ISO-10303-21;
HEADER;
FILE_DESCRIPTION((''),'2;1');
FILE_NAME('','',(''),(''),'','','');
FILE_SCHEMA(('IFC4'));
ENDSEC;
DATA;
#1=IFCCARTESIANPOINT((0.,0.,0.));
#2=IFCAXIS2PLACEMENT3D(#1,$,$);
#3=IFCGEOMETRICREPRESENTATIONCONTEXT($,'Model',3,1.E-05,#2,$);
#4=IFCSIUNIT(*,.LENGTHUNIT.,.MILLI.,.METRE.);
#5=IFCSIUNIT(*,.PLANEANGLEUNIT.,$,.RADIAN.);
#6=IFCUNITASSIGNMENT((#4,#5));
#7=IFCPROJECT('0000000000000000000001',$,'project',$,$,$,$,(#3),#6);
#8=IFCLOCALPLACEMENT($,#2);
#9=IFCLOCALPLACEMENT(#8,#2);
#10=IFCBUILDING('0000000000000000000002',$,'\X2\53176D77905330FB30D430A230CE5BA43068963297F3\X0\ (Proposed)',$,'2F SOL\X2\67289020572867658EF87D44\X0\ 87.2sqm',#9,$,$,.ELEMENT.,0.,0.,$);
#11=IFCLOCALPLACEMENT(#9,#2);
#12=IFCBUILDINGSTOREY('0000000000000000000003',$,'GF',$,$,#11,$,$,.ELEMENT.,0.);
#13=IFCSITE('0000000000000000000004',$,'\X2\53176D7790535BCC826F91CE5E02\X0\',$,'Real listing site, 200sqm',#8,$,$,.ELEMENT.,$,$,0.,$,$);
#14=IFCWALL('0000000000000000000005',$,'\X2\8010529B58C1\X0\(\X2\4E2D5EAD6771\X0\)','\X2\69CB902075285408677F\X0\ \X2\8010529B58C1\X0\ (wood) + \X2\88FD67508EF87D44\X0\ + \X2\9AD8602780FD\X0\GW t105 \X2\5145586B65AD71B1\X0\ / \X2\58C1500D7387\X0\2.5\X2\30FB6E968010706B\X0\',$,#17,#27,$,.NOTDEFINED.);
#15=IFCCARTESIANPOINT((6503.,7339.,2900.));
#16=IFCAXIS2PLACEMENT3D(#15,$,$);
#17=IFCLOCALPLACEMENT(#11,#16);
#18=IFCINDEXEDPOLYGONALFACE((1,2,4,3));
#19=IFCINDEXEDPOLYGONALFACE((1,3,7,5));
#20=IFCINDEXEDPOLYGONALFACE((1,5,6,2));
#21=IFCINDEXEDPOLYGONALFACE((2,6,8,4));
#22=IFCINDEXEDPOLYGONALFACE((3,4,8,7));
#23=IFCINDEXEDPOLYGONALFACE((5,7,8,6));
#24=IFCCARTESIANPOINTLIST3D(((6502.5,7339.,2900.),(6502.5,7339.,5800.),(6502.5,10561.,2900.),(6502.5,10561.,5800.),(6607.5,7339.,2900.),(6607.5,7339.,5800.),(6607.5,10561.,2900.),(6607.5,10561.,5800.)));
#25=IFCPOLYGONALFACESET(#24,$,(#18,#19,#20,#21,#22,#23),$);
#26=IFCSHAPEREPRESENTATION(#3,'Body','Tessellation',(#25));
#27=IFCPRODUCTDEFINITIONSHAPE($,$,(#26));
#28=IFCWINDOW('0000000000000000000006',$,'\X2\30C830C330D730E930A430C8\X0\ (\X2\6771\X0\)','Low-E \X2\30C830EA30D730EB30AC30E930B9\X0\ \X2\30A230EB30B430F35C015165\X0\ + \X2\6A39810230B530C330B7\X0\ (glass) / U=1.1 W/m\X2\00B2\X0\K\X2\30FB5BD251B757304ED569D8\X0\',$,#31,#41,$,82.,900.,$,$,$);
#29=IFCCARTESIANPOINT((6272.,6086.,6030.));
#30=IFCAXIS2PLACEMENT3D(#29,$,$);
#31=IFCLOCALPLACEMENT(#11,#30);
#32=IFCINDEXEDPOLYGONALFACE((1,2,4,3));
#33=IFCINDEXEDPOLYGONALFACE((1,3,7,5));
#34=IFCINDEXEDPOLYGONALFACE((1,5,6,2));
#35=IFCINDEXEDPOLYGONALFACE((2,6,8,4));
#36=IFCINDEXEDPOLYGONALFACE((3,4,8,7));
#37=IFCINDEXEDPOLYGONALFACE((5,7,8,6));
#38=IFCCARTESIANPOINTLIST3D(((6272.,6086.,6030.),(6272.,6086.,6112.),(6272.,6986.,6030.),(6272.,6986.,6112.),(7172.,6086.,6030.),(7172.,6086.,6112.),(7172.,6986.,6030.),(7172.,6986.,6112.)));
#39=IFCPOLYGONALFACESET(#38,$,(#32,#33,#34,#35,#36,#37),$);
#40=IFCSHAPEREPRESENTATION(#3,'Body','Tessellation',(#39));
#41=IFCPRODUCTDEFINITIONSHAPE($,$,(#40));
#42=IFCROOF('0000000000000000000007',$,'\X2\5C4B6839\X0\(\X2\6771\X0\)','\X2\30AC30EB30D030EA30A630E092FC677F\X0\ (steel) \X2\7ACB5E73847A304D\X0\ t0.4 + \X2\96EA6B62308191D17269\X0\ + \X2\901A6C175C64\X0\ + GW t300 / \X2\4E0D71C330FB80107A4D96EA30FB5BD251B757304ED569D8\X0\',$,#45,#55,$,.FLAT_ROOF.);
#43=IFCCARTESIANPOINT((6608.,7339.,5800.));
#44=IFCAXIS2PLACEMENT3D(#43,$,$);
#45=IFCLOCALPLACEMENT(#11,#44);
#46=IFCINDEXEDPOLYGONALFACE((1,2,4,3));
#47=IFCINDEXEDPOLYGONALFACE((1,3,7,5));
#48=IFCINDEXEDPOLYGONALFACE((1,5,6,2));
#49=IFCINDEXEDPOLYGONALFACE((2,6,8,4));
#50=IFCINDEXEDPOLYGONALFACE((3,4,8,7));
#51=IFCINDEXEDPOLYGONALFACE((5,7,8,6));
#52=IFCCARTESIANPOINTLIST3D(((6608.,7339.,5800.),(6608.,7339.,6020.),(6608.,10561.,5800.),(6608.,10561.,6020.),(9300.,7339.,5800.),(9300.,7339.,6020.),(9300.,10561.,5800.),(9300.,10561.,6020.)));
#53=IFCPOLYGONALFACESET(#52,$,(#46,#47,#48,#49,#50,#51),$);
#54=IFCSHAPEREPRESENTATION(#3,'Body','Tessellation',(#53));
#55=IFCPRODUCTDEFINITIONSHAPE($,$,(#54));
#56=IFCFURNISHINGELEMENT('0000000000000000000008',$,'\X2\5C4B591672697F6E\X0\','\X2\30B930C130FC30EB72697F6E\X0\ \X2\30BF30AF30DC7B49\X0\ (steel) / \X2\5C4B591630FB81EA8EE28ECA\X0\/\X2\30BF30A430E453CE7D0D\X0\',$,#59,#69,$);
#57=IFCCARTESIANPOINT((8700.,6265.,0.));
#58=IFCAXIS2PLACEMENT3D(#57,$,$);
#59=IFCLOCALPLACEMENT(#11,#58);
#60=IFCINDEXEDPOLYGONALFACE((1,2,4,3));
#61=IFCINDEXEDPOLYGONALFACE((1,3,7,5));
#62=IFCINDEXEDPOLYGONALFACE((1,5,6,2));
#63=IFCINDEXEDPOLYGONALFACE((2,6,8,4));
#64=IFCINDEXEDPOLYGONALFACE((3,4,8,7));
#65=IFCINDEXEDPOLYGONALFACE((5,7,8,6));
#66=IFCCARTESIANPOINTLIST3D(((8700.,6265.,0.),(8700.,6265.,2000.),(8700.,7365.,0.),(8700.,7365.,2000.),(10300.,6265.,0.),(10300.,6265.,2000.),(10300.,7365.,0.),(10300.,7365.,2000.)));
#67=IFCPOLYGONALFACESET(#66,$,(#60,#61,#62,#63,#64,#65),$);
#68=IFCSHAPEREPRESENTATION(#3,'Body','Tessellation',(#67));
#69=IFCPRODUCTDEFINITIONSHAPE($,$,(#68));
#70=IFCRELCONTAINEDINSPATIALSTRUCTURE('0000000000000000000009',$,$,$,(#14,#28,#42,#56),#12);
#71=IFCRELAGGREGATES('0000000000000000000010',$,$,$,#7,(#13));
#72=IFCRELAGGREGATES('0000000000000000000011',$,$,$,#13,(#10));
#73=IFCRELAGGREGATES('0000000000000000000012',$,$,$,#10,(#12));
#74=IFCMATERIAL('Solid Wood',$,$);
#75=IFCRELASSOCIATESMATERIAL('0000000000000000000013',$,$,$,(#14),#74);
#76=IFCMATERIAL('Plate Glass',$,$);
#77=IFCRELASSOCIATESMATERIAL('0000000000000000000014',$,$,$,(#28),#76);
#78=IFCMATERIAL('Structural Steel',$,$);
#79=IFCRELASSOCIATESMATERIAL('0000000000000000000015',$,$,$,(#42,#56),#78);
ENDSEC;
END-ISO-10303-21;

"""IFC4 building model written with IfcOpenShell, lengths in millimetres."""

from ifc_helpers import new_model, si_unit, frame, frame_2d, origin, place, context, project, spatial, rectangle, extrude, material, element, save


model = new_model("IFC4")

# Units and contexts
model_context = context("Model", 3, precision=1e-05, world=origin())
ifc_project = project(units=[si_unit("LENGTHUNIT", "METRE", prefix="MILLI"), si_unit("PLANEANGLEUNIT", "RADIAN")], contexts=[model_context])

# Site, building, storey
site_placement = place(None, origin())
site = spatial("IfcSite", under=ifc_project, at=site_placement, Name="北海道富良野市", ObjectType="Real listing site, 200sqm", CompositionType="ELEMENT", RefElevation=0.0)
building_placement = place(site_placement, origin())
building = spatial("IfcBuilding", under=site, at=building_placement, Name="北海道・ピアノ室と防音 (Proposed)", ObjectType="2F SOL木造在来軸組 87.2sqm", CompositionType="ELEMENT", ElevationOfRefHeight=0.0, ElevationOfTerrain=0.0)
storey_placement = place(building_placement, origin())
storey = spatial("IfcBuildingStorey", under=building, at=storey_placement, Name="GF", CompositionType="ELEMENT", Elevation=0.0)

# Shared definitions
ifc_material_1 = material(Name="Solid Wood")

# Shared definitions
ifc_material_2 = material(Name="Plate Glass")

# Wall
wall_1_placement = place(storey_placement, frame((6503.0, 7339.0, 2900.0)))
element("IfcWall", 1, at=wall_1_placement, inside=storey, material=ifc_material_1, Name="耐力壁(中庭東)", Description="構造用合板 耐力壁 (wood) + 製材軸組 + 高性能GW t105 充填断熱 / 壁倍率2.5・準耐火", PredefinedType="NOTDEFINED", context=model_context, shape_type="SweptSolid", body=[
    extrude(rectangle(XDim=105.0, YDim=3222.0, at=frame_2d((52.0, 1611.0))), frame((6503.0, 7339.0, 2900.0)), (0.0, 0.0, 1.0), 2900.0),
])

# Window
window_1_placement = place(storey_placement, frame((6272.0, 6086.0, 6030.0)))
element("IfcWindow", 2, at=window_1_placement, inside=storey, material=ifc_material_2, Name="トップライト (東)", Description="Low-E トリプルガラス アルゴン封入 + 樹脂サッシ (glass) / U=1.1 W/m²K・寒冷地仕様", OverallHeight=82.0, OverallWidth=900.0, context=model_context, shape_type="SweptSolid", body=[
    extrude(rectangle(XDim=900.0, YDim=900.0, at=frame_2d((450.0, 450.0))), frame((6272.0, 6086.0, 6030.0)), (0.0, 0.0, 1.0), 82.0),
])

# Roof
ifc_material_3 = material(Name="Structural Steel")
for number, where, name in (
    (3, (6608.0, 7339.0, 5800.0), "屋根(東)"),
):
    element("IfcRoof", number, at=place(storey_placement, frame(where)), inside=storey, material=ifc_material_3, Name=name, Description="ガルバリウム鋼板 (steel) 立平葺き t0.4 + 雪止め金物 + 通気層 + GW t300 / 不燃・耐積雪・寒冷地仕様", PredefinedType="FLAT_ROOF", context=model_context, shape_type="SweptSolid", body=[
        extrude(rectangle(XDim=2692.0, YDim=3222.0, at=frame_2d((1346.0, 1611.0))), frame((6608.0, 7339.0, 5800.0)), (0.0, 0.0, 1.0), 220.0),
    ])

# Furnishing element
furnishing_placement = place(storey_placement, frame((8700.0, 6265.0, 0.0)))
element("IfcFurnishingElement", 4, at=furnishing_placement, inside=storey, material=ifc_material_3, Name="屋外物置", Description="スチール物置 タクボ等 (steel) / 屋外・自転車/タイヤ収納", context=model_context, shape_type="SweptSolid", body=[
    extrude(rectangle(XDim=1600.0, YDim=1100.0, at=frame_2d((800.0, 550.0))), frame((8700.0, 6265.0, 0.0)), (0.0, 0.0, 1.0), 2000.0),
])

save(model, "model.ifc")
